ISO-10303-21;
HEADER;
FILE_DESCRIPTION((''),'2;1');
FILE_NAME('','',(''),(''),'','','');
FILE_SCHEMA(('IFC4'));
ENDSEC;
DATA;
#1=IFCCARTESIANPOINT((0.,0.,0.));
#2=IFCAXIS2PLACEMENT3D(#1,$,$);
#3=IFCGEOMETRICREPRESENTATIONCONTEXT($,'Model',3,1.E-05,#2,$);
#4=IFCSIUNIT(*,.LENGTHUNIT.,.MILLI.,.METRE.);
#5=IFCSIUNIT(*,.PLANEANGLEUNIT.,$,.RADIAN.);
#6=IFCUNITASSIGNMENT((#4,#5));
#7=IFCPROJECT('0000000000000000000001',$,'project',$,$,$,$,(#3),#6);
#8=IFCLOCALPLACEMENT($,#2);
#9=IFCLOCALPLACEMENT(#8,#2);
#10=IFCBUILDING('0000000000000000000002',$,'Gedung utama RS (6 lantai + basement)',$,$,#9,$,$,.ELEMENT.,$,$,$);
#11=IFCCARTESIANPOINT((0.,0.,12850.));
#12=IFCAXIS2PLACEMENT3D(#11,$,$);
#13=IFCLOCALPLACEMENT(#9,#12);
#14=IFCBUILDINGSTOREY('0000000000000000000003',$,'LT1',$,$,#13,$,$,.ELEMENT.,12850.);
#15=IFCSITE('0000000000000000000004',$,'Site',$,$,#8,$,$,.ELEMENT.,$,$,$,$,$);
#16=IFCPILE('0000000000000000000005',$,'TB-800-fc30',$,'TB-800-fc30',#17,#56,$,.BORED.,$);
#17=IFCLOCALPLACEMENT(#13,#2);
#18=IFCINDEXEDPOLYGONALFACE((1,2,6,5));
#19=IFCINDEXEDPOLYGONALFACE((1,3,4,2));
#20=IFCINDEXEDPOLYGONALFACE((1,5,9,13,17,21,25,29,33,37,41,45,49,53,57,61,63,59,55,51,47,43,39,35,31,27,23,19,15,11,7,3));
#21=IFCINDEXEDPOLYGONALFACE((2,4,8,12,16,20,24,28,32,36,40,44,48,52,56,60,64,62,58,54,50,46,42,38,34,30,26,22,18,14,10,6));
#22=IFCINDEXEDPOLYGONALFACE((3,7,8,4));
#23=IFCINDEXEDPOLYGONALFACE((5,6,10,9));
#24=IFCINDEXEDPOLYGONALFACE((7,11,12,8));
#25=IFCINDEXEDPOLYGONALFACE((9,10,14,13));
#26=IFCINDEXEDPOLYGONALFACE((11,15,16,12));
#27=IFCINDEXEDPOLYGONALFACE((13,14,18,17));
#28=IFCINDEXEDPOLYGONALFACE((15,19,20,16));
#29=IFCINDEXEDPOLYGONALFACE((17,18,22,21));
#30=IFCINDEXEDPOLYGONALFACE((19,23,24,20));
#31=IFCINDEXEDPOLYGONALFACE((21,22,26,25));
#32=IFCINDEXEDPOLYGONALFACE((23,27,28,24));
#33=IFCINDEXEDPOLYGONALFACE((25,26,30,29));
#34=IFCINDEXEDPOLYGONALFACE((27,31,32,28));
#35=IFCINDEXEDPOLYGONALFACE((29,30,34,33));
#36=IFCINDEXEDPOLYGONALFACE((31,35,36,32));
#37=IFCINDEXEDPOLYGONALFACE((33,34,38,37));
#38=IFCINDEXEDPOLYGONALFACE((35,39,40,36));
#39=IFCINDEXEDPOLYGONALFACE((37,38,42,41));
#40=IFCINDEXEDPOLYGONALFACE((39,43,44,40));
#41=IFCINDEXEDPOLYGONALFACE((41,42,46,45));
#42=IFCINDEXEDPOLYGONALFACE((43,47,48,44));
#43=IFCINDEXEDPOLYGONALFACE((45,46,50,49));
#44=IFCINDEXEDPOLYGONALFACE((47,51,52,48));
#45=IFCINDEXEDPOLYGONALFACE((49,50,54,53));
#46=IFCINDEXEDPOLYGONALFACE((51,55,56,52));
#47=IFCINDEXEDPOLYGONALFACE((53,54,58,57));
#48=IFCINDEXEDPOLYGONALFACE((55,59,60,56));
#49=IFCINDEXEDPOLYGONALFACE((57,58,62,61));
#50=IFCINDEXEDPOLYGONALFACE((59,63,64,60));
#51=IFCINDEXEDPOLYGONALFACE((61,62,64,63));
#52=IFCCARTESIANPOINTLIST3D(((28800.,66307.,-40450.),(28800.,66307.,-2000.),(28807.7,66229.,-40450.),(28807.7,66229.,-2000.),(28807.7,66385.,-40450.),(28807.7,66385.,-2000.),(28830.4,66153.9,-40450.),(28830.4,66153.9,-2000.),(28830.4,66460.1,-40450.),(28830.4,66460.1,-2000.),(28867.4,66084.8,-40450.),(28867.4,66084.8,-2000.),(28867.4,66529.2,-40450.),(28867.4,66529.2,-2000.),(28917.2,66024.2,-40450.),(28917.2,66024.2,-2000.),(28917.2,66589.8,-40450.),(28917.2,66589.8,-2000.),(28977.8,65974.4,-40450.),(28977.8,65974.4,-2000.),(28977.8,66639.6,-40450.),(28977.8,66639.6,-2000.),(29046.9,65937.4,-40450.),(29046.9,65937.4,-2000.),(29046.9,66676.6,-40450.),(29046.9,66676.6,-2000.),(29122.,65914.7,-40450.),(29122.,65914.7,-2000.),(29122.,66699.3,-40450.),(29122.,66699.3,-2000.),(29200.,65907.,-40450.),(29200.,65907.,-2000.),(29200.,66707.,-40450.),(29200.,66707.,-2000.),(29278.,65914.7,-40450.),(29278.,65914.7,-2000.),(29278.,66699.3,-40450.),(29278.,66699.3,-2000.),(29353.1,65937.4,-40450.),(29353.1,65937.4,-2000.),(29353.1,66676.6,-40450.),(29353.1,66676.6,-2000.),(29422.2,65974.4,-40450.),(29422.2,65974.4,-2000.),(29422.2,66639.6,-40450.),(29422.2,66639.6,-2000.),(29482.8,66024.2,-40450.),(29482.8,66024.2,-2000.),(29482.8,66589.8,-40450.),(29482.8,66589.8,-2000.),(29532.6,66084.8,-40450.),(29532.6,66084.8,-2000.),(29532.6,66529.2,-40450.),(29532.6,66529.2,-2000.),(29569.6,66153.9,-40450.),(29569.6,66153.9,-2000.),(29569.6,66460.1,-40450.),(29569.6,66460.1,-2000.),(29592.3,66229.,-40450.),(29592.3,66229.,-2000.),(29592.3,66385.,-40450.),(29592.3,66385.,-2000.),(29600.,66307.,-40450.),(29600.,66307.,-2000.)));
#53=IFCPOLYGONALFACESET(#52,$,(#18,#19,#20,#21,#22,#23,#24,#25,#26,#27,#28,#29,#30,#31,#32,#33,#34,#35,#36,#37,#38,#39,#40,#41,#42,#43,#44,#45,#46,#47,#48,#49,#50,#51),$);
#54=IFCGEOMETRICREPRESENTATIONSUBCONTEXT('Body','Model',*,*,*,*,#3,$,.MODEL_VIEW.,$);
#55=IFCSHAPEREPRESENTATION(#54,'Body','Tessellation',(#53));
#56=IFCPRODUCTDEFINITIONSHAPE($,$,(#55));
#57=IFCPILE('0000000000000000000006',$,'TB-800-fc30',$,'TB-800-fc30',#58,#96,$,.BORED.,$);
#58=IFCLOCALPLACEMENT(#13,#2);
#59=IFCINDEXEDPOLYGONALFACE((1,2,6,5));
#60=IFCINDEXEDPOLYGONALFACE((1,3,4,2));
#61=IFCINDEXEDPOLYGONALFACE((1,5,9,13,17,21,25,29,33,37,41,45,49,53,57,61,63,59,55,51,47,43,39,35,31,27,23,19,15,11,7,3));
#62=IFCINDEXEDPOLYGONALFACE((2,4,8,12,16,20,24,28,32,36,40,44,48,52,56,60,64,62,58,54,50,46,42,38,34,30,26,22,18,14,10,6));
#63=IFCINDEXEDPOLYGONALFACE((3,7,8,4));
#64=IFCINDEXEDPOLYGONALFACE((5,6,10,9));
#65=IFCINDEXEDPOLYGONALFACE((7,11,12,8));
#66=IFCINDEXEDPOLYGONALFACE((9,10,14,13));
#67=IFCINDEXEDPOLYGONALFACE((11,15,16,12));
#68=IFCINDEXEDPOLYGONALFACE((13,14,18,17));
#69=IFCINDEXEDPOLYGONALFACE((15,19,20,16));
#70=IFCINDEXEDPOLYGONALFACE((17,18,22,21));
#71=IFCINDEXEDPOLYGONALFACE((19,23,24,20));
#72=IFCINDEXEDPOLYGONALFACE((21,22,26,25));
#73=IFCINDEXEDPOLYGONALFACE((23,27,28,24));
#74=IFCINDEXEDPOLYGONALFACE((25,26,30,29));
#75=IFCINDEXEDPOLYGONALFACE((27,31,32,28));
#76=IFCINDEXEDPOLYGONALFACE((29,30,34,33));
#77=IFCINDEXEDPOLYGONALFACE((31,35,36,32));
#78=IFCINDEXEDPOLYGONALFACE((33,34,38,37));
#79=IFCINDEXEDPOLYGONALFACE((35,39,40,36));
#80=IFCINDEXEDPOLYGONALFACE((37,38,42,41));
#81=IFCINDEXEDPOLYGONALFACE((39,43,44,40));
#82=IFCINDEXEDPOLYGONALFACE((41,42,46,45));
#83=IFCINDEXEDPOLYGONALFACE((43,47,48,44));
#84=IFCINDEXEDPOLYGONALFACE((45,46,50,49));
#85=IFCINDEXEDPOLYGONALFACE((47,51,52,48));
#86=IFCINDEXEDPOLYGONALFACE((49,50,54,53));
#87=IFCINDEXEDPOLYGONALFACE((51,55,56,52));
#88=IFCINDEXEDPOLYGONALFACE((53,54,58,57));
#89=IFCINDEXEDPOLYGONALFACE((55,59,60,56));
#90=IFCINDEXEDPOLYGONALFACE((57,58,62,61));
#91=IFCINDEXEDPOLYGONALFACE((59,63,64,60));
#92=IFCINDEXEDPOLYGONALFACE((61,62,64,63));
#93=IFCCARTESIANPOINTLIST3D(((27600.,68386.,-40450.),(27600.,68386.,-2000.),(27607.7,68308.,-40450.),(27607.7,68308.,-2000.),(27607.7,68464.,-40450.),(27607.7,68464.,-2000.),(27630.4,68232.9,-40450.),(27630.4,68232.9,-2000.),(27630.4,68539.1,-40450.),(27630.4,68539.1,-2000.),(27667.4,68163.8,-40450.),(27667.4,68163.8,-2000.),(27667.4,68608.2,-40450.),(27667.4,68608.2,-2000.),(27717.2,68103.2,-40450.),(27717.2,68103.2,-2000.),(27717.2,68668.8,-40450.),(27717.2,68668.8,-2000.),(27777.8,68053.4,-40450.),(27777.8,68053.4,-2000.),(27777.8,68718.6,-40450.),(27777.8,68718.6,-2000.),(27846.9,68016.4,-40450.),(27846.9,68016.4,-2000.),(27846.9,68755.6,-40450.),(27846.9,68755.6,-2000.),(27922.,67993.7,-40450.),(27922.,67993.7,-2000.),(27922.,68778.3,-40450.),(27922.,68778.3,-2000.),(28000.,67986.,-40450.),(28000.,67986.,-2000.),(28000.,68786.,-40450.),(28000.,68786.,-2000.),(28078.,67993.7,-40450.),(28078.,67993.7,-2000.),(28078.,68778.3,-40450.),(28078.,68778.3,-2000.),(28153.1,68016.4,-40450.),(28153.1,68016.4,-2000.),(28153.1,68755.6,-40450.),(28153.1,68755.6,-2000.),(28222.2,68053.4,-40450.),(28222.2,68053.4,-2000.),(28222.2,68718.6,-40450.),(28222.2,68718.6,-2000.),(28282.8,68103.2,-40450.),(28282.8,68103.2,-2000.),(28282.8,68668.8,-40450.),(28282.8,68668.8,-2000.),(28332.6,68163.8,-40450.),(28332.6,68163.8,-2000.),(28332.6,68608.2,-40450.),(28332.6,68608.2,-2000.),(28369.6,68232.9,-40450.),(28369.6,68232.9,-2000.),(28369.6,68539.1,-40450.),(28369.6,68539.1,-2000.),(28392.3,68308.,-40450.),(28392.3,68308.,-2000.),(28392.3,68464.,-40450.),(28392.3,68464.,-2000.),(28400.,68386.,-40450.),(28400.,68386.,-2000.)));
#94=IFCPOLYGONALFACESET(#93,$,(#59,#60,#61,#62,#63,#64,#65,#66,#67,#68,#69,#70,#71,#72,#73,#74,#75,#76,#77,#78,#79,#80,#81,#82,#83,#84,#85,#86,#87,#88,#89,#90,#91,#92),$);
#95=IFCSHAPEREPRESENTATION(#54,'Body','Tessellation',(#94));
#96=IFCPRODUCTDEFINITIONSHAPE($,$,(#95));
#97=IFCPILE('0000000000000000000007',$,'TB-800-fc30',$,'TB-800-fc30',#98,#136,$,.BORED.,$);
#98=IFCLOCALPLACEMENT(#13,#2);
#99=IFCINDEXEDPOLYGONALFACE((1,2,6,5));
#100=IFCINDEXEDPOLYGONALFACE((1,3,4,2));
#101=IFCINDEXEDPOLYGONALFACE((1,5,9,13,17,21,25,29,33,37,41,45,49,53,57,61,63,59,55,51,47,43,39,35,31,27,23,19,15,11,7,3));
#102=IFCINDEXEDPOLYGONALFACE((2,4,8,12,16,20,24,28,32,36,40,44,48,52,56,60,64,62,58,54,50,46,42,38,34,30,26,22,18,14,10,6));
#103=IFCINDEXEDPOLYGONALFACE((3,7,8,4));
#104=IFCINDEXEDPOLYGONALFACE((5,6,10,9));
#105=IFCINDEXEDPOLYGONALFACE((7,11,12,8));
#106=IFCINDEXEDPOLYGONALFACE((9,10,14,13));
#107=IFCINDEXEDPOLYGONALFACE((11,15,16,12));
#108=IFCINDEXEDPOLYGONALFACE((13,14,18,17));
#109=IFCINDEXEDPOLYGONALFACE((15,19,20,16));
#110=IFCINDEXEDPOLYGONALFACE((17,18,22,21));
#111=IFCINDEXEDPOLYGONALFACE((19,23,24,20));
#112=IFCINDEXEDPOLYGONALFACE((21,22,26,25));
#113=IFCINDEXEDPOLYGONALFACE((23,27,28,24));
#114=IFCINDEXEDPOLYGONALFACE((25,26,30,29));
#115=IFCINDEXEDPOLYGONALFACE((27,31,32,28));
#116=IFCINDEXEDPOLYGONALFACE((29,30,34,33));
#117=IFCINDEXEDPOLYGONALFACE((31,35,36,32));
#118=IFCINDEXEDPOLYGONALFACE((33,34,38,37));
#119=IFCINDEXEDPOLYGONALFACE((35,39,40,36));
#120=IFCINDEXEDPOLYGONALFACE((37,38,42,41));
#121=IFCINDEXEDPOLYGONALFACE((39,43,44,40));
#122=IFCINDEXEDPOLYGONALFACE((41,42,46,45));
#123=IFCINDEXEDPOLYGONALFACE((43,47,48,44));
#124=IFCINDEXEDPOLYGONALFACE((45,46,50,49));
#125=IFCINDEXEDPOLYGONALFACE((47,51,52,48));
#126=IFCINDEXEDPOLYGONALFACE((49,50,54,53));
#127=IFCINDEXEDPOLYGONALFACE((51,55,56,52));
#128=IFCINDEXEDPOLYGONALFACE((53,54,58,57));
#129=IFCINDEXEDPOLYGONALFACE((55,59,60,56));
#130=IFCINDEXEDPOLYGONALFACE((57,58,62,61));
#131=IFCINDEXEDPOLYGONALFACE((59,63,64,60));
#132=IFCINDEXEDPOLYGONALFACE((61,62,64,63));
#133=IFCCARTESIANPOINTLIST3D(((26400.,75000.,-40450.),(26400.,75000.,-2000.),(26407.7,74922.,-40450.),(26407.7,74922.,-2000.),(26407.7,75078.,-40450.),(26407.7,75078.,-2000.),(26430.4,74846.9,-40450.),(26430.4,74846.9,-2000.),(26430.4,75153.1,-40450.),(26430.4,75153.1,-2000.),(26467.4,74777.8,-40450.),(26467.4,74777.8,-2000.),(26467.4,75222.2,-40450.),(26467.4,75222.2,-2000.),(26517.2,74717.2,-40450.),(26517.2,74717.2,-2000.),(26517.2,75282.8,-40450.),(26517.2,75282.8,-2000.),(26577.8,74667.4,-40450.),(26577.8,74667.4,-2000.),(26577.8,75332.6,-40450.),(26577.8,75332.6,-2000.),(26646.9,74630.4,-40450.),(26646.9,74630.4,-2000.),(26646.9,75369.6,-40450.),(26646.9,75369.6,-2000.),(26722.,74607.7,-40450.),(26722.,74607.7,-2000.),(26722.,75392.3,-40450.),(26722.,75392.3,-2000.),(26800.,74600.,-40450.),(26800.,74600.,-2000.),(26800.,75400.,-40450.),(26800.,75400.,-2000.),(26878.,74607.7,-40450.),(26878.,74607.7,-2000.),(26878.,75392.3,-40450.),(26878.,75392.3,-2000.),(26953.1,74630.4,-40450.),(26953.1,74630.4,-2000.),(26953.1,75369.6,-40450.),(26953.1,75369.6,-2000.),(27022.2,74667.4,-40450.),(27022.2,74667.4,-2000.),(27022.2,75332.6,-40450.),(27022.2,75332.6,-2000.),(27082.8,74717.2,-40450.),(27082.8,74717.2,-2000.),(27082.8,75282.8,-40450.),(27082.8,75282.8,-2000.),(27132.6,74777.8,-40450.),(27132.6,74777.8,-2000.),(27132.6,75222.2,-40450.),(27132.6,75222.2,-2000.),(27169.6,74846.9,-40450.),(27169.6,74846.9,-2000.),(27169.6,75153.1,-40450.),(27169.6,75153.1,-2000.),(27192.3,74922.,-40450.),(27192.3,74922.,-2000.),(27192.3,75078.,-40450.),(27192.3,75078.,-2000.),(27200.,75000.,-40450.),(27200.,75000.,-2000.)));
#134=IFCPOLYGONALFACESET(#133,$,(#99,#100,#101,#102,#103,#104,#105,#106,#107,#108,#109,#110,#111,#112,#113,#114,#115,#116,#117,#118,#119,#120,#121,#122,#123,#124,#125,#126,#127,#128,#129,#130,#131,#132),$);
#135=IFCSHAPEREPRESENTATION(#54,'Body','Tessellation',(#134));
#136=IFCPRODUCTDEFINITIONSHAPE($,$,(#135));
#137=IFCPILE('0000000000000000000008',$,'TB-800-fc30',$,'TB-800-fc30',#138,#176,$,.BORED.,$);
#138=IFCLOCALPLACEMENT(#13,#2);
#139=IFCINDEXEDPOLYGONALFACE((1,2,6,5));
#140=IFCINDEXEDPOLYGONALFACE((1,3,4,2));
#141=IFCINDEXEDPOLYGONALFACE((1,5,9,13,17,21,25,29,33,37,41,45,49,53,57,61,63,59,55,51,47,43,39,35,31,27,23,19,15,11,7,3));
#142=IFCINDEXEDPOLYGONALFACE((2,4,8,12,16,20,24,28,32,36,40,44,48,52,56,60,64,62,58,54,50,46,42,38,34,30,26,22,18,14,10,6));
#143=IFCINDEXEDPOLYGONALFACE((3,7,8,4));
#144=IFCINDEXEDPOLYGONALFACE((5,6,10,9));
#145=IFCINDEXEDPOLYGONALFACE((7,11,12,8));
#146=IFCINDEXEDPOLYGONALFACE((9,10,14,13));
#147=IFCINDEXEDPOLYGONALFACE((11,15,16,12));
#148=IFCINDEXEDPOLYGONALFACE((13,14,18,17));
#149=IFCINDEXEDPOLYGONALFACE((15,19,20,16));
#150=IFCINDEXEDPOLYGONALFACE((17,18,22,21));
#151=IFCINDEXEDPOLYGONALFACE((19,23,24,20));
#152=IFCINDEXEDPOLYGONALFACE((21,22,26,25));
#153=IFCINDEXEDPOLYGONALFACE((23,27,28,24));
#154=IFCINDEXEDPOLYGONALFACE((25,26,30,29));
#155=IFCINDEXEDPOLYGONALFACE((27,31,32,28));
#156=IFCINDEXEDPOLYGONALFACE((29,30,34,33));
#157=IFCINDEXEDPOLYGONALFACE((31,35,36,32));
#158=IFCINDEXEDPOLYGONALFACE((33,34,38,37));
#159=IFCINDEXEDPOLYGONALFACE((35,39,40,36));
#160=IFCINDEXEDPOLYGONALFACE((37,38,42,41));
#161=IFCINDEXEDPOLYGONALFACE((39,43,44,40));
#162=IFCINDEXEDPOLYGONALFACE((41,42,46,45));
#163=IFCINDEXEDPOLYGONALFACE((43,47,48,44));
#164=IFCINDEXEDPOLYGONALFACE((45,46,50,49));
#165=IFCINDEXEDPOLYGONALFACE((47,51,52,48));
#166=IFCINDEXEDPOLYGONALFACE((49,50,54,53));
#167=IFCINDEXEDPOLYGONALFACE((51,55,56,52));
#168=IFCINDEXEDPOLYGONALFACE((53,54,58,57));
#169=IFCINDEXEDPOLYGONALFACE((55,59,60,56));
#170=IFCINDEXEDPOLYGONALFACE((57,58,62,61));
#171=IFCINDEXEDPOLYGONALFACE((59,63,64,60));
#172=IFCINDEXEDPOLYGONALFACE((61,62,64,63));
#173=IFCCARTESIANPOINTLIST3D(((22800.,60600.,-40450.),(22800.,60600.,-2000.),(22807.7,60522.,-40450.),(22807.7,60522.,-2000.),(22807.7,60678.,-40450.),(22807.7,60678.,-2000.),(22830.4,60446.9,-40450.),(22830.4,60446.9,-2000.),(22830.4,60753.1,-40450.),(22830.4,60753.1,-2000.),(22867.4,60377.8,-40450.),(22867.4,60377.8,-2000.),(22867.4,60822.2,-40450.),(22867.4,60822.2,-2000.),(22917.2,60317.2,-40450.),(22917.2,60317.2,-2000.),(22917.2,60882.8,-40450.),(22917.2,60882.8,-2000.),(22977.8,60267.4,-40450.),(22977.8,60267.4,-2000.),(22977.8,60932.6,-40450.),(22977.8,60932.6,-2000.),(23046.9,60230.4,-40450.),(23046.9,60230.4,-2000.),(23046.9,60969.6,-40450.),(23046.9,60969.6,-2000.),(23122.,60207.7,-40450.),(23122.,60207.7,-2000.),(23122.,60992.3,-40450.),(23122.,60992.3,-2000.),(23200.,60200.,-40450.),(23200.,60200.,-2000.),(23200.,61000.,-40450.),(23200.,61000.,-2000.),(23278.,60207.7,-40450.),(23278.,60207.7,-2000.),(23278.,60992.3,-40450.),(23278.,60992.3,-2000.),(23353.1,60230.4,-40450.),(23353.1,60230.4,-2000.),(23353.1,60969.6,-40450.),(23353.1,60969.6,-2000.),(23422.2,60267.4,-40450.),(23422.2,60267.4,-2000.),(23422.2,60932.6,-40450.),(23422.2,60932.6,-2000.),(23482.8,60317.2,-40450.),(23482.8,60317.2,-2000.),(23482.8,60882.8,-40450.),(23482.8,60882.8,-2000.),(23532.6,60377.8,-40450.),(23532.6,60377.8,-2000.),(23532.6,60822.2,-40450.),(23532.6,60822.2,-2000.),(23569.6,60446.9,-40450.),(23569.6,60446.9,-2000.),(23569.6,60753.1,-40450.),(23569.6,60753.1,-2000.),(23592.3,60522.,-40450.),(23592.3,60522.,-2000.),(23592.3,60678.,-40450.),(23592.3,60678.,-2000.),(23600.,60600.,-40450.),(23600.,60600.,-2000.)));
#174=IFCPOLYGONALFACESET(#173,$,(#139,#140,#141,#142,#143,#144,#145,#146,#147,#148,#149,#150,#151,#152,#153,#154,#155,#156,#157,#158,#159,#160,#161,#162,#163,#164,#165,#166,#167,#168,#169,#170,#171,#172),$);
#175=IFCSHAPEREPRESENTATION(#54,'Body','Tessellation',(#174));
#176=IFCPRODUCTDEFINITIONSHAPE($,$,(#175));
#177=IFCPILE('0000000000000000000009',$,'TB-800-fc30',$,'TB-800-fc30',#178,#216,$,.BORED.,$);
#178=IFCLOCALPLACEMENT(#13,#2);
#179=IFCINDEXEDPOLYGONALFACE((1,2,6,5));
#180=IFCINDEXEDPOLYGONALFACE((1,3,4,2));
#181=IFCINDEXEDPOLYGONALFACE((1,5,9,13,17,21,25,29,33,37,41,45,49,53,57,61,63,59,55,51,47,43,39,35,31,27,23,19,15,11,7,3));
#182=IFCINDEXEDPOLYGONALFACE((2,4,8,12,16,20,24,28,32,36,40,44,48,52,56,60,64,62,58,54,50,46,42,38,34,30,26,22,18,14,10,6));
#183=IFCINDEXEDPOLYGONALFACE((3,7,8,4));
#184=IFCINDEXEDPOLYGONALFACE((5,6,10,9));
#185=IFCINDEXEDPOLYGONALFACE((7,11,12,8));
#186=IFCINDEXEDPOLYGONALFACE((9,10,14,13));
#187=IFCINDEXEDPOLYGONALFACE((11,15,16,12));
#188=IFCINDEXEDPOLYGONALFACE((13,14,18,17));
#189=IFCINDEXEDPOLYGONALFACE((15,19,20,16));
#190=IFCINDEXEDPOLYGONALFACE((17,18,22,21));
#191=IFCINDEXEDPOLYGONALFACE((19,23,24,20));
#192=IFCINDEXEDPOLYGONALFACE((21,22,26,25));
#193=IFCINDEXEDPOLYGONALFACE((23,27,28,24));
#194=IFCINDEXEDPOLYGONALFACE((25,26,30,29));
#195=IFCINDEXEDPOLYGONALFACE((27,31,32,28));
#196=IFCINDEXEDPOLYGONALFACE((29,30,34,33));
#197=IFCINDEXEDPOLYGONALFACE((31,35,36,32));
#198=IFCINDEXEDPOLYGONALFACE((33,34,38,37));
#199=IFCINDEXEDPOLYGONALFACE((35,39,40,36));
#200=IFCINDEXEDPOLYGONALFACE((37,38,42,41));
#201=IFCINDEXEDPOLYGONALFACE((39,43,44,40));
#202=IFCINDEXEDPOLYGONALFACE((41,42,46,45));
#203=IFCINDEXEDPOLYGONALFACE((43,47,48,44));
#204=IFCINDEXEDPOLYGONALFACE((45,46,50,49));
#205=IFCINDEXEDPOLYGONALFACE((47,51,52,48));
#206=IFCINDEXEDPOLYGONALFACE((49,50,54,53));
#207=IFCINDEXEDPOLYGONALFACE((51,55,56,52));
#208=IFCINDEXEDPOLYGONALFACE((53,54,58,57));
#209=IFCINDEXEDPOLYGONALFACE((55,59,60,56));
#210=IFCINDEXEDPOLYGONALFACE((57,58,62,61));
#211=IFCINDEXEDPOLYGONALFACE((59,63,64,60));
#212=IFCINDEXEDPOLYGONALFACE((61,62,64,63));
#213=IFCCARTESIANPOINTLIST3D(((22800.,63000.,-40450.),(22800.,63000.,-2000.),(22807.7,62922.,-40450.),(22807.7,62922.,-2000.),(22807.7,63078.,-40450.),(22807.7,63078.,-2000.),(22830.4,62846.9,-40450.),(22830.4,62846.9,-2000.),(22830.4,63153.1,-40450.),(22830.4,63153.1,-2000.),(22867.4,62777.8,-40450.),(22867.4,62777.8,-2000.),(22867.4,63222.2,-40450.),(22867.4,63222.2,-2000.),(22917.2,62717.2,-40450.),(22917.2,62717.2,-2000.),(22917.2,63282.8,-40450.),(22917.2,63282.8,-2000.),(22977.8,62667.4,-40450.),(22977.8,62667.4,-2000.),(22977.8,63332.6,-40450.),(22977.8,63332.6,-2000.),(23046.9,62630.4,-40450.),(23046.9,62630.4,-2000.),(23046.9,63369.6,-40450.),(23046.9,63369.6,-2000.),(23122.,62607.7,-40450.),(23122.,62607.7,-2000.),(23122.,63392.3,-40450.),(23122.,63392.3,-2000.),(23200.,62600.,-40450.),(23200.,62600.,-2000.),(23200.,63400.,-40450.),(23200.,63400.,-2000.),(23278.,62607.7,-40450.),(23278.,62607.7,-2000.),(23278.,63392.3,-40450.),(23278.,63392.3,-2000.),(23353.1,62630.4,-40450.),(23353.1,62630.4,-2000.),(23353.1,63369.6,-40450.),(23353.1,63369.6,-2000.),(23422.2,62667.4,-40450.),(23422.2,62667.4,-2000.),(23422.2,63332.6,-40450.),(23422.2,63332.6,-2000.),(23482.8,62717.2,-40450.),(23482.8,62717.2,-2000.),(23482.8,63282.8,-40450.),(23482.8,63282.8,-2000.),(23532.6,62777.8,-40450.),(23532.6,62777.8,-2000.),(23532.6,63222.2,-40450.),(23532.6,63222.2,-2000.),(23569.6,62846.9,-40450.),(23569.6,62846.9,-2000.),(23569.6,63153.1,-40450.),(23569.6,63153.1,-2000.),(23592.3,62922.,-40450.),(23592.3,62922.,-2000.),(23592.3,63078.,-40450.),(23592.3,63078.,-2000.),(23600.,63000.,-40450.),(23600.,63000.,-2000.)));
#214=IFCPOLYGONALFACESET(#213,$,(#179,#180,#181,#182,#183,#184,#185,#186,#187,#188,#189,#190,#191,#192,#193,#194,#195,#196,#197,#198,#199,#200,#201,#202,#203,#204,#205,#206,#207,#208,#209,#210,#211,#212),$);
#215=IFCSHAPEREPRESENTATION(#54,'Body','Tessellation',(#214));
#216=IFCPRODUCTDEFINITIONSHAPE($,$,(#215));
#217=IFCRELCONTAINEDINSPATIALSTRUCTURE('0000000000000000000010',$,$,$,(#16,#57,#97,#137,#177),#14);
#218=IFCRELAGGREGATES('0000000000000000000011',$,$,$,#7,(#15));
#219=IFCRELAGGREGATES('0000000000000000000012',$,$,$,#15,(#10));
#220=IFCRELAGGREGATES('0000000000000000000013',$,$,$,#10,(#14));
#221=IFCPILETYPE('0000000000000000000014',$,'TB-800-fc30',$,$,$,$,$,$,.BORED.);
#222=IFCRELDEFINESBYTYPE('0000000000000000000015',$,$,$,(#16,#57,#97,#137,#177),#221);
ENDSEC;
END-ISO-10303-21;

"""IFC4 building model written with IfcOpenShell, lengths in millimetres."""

from ifc_helpers import new_model, si_unit, frame, origin, origin_2d, place, context, subcontext, project, spatial, circle, extrude, material_profile, profile_set, profile_usage, type_object, element, save


model = new_model("IFC4")

# Units and contexts
model_context = context("Model", 3, precision=1e-05, world=origin())
body_context = subcontext(model_context, "Body", "Model", "MODEL_VIEW")
ifc_project = project(units=[si_unit("LENGTHUNIT", "METRE", prefix="MILLI"), si_unit("PLANEANGLEUNIT", "RADIAN")], contexts=[model_context])

# Site, building, storey
site_placement = place(None, origin())
site = spatial("IfcSite", under=ifc_project, at=site_placement, Name="Site", CompositionType="ELEMENT")
building_placement = place(site_placement, origin())
building = spatial("IfcBuilding", under=site, at=building_placement, Name="Gedung utama RS (6 lantai + basement)", CompositionType="ELEMENT")
storey_placement = place(building_placement, frame((0.0, 0.0, 12850.0)))
storey = spatial("IfcBuildingStorey", under=building, at=storey_placement, Name="LT1", CompositionType="ELEMENT", Elevation=12850.0)

# Piles
ifc_material_profile = material_profile(None, circle(Radius=400.0, at=origin_2d()), Name="TB-800-fc30")
ifc_profile_set = profile_set([ifc_material_profile], Name="TB-800-fc30")
ifc_profile_usage = profile_usage(ifc_profile_set, cardinal=5)
pile_type = type_object("IfcPileType", Name="TB-800-fc30", PredefinedType="BORED", material=ifc_profile_set)
for number, where, z_axis, x_axis, name in (
    (1, (29200.0, 66307.0, -40450.0), (0.0, 0.0, 1.0), (1.0, 0.0, 0.0), "TB-800-fc30"),
    (2, (28000.0, 68386.0, -40450.0), (0.0, 0.0, 1.0), (1.0, 0.0, 0.0), "TB-800-fc30"),
    (3, (26800.0, 75000.0, -40450.0), (0.0, 0.0, 1.0), (1.0, 0.0, 0.0), "TB-800-fc30"),
    (4, (23200.0, 60600.0, -40450.0), (0.0, 0.0, 1.0), (1.0, 0.0, 0.0), "TB-800-fc30"),
    (5, (23200.0, 63000.0, -40450.0), (0.0, 0.0, 1.0), (1.0, 0.0, 0.0), "TB-800-fc30"),
):
    element("IfcPile", number, at=place(storey_placement, frame(where, z_axis=z_axis, x_axis=x_axis)), inside=storey, type_object=pile_type, material=ifc_profile_usage, Name=name, ObjectType="TB-800-fc30", PredefinedType="BORED", context=body_context, shape_type="SweptSolid", body=[
        extrude(circle(Radius=400.0, at=origin_2d()), origin(), (0.0, 0.0, 1.0), 38450.0),
    ])

save(model, "model.ifc")
